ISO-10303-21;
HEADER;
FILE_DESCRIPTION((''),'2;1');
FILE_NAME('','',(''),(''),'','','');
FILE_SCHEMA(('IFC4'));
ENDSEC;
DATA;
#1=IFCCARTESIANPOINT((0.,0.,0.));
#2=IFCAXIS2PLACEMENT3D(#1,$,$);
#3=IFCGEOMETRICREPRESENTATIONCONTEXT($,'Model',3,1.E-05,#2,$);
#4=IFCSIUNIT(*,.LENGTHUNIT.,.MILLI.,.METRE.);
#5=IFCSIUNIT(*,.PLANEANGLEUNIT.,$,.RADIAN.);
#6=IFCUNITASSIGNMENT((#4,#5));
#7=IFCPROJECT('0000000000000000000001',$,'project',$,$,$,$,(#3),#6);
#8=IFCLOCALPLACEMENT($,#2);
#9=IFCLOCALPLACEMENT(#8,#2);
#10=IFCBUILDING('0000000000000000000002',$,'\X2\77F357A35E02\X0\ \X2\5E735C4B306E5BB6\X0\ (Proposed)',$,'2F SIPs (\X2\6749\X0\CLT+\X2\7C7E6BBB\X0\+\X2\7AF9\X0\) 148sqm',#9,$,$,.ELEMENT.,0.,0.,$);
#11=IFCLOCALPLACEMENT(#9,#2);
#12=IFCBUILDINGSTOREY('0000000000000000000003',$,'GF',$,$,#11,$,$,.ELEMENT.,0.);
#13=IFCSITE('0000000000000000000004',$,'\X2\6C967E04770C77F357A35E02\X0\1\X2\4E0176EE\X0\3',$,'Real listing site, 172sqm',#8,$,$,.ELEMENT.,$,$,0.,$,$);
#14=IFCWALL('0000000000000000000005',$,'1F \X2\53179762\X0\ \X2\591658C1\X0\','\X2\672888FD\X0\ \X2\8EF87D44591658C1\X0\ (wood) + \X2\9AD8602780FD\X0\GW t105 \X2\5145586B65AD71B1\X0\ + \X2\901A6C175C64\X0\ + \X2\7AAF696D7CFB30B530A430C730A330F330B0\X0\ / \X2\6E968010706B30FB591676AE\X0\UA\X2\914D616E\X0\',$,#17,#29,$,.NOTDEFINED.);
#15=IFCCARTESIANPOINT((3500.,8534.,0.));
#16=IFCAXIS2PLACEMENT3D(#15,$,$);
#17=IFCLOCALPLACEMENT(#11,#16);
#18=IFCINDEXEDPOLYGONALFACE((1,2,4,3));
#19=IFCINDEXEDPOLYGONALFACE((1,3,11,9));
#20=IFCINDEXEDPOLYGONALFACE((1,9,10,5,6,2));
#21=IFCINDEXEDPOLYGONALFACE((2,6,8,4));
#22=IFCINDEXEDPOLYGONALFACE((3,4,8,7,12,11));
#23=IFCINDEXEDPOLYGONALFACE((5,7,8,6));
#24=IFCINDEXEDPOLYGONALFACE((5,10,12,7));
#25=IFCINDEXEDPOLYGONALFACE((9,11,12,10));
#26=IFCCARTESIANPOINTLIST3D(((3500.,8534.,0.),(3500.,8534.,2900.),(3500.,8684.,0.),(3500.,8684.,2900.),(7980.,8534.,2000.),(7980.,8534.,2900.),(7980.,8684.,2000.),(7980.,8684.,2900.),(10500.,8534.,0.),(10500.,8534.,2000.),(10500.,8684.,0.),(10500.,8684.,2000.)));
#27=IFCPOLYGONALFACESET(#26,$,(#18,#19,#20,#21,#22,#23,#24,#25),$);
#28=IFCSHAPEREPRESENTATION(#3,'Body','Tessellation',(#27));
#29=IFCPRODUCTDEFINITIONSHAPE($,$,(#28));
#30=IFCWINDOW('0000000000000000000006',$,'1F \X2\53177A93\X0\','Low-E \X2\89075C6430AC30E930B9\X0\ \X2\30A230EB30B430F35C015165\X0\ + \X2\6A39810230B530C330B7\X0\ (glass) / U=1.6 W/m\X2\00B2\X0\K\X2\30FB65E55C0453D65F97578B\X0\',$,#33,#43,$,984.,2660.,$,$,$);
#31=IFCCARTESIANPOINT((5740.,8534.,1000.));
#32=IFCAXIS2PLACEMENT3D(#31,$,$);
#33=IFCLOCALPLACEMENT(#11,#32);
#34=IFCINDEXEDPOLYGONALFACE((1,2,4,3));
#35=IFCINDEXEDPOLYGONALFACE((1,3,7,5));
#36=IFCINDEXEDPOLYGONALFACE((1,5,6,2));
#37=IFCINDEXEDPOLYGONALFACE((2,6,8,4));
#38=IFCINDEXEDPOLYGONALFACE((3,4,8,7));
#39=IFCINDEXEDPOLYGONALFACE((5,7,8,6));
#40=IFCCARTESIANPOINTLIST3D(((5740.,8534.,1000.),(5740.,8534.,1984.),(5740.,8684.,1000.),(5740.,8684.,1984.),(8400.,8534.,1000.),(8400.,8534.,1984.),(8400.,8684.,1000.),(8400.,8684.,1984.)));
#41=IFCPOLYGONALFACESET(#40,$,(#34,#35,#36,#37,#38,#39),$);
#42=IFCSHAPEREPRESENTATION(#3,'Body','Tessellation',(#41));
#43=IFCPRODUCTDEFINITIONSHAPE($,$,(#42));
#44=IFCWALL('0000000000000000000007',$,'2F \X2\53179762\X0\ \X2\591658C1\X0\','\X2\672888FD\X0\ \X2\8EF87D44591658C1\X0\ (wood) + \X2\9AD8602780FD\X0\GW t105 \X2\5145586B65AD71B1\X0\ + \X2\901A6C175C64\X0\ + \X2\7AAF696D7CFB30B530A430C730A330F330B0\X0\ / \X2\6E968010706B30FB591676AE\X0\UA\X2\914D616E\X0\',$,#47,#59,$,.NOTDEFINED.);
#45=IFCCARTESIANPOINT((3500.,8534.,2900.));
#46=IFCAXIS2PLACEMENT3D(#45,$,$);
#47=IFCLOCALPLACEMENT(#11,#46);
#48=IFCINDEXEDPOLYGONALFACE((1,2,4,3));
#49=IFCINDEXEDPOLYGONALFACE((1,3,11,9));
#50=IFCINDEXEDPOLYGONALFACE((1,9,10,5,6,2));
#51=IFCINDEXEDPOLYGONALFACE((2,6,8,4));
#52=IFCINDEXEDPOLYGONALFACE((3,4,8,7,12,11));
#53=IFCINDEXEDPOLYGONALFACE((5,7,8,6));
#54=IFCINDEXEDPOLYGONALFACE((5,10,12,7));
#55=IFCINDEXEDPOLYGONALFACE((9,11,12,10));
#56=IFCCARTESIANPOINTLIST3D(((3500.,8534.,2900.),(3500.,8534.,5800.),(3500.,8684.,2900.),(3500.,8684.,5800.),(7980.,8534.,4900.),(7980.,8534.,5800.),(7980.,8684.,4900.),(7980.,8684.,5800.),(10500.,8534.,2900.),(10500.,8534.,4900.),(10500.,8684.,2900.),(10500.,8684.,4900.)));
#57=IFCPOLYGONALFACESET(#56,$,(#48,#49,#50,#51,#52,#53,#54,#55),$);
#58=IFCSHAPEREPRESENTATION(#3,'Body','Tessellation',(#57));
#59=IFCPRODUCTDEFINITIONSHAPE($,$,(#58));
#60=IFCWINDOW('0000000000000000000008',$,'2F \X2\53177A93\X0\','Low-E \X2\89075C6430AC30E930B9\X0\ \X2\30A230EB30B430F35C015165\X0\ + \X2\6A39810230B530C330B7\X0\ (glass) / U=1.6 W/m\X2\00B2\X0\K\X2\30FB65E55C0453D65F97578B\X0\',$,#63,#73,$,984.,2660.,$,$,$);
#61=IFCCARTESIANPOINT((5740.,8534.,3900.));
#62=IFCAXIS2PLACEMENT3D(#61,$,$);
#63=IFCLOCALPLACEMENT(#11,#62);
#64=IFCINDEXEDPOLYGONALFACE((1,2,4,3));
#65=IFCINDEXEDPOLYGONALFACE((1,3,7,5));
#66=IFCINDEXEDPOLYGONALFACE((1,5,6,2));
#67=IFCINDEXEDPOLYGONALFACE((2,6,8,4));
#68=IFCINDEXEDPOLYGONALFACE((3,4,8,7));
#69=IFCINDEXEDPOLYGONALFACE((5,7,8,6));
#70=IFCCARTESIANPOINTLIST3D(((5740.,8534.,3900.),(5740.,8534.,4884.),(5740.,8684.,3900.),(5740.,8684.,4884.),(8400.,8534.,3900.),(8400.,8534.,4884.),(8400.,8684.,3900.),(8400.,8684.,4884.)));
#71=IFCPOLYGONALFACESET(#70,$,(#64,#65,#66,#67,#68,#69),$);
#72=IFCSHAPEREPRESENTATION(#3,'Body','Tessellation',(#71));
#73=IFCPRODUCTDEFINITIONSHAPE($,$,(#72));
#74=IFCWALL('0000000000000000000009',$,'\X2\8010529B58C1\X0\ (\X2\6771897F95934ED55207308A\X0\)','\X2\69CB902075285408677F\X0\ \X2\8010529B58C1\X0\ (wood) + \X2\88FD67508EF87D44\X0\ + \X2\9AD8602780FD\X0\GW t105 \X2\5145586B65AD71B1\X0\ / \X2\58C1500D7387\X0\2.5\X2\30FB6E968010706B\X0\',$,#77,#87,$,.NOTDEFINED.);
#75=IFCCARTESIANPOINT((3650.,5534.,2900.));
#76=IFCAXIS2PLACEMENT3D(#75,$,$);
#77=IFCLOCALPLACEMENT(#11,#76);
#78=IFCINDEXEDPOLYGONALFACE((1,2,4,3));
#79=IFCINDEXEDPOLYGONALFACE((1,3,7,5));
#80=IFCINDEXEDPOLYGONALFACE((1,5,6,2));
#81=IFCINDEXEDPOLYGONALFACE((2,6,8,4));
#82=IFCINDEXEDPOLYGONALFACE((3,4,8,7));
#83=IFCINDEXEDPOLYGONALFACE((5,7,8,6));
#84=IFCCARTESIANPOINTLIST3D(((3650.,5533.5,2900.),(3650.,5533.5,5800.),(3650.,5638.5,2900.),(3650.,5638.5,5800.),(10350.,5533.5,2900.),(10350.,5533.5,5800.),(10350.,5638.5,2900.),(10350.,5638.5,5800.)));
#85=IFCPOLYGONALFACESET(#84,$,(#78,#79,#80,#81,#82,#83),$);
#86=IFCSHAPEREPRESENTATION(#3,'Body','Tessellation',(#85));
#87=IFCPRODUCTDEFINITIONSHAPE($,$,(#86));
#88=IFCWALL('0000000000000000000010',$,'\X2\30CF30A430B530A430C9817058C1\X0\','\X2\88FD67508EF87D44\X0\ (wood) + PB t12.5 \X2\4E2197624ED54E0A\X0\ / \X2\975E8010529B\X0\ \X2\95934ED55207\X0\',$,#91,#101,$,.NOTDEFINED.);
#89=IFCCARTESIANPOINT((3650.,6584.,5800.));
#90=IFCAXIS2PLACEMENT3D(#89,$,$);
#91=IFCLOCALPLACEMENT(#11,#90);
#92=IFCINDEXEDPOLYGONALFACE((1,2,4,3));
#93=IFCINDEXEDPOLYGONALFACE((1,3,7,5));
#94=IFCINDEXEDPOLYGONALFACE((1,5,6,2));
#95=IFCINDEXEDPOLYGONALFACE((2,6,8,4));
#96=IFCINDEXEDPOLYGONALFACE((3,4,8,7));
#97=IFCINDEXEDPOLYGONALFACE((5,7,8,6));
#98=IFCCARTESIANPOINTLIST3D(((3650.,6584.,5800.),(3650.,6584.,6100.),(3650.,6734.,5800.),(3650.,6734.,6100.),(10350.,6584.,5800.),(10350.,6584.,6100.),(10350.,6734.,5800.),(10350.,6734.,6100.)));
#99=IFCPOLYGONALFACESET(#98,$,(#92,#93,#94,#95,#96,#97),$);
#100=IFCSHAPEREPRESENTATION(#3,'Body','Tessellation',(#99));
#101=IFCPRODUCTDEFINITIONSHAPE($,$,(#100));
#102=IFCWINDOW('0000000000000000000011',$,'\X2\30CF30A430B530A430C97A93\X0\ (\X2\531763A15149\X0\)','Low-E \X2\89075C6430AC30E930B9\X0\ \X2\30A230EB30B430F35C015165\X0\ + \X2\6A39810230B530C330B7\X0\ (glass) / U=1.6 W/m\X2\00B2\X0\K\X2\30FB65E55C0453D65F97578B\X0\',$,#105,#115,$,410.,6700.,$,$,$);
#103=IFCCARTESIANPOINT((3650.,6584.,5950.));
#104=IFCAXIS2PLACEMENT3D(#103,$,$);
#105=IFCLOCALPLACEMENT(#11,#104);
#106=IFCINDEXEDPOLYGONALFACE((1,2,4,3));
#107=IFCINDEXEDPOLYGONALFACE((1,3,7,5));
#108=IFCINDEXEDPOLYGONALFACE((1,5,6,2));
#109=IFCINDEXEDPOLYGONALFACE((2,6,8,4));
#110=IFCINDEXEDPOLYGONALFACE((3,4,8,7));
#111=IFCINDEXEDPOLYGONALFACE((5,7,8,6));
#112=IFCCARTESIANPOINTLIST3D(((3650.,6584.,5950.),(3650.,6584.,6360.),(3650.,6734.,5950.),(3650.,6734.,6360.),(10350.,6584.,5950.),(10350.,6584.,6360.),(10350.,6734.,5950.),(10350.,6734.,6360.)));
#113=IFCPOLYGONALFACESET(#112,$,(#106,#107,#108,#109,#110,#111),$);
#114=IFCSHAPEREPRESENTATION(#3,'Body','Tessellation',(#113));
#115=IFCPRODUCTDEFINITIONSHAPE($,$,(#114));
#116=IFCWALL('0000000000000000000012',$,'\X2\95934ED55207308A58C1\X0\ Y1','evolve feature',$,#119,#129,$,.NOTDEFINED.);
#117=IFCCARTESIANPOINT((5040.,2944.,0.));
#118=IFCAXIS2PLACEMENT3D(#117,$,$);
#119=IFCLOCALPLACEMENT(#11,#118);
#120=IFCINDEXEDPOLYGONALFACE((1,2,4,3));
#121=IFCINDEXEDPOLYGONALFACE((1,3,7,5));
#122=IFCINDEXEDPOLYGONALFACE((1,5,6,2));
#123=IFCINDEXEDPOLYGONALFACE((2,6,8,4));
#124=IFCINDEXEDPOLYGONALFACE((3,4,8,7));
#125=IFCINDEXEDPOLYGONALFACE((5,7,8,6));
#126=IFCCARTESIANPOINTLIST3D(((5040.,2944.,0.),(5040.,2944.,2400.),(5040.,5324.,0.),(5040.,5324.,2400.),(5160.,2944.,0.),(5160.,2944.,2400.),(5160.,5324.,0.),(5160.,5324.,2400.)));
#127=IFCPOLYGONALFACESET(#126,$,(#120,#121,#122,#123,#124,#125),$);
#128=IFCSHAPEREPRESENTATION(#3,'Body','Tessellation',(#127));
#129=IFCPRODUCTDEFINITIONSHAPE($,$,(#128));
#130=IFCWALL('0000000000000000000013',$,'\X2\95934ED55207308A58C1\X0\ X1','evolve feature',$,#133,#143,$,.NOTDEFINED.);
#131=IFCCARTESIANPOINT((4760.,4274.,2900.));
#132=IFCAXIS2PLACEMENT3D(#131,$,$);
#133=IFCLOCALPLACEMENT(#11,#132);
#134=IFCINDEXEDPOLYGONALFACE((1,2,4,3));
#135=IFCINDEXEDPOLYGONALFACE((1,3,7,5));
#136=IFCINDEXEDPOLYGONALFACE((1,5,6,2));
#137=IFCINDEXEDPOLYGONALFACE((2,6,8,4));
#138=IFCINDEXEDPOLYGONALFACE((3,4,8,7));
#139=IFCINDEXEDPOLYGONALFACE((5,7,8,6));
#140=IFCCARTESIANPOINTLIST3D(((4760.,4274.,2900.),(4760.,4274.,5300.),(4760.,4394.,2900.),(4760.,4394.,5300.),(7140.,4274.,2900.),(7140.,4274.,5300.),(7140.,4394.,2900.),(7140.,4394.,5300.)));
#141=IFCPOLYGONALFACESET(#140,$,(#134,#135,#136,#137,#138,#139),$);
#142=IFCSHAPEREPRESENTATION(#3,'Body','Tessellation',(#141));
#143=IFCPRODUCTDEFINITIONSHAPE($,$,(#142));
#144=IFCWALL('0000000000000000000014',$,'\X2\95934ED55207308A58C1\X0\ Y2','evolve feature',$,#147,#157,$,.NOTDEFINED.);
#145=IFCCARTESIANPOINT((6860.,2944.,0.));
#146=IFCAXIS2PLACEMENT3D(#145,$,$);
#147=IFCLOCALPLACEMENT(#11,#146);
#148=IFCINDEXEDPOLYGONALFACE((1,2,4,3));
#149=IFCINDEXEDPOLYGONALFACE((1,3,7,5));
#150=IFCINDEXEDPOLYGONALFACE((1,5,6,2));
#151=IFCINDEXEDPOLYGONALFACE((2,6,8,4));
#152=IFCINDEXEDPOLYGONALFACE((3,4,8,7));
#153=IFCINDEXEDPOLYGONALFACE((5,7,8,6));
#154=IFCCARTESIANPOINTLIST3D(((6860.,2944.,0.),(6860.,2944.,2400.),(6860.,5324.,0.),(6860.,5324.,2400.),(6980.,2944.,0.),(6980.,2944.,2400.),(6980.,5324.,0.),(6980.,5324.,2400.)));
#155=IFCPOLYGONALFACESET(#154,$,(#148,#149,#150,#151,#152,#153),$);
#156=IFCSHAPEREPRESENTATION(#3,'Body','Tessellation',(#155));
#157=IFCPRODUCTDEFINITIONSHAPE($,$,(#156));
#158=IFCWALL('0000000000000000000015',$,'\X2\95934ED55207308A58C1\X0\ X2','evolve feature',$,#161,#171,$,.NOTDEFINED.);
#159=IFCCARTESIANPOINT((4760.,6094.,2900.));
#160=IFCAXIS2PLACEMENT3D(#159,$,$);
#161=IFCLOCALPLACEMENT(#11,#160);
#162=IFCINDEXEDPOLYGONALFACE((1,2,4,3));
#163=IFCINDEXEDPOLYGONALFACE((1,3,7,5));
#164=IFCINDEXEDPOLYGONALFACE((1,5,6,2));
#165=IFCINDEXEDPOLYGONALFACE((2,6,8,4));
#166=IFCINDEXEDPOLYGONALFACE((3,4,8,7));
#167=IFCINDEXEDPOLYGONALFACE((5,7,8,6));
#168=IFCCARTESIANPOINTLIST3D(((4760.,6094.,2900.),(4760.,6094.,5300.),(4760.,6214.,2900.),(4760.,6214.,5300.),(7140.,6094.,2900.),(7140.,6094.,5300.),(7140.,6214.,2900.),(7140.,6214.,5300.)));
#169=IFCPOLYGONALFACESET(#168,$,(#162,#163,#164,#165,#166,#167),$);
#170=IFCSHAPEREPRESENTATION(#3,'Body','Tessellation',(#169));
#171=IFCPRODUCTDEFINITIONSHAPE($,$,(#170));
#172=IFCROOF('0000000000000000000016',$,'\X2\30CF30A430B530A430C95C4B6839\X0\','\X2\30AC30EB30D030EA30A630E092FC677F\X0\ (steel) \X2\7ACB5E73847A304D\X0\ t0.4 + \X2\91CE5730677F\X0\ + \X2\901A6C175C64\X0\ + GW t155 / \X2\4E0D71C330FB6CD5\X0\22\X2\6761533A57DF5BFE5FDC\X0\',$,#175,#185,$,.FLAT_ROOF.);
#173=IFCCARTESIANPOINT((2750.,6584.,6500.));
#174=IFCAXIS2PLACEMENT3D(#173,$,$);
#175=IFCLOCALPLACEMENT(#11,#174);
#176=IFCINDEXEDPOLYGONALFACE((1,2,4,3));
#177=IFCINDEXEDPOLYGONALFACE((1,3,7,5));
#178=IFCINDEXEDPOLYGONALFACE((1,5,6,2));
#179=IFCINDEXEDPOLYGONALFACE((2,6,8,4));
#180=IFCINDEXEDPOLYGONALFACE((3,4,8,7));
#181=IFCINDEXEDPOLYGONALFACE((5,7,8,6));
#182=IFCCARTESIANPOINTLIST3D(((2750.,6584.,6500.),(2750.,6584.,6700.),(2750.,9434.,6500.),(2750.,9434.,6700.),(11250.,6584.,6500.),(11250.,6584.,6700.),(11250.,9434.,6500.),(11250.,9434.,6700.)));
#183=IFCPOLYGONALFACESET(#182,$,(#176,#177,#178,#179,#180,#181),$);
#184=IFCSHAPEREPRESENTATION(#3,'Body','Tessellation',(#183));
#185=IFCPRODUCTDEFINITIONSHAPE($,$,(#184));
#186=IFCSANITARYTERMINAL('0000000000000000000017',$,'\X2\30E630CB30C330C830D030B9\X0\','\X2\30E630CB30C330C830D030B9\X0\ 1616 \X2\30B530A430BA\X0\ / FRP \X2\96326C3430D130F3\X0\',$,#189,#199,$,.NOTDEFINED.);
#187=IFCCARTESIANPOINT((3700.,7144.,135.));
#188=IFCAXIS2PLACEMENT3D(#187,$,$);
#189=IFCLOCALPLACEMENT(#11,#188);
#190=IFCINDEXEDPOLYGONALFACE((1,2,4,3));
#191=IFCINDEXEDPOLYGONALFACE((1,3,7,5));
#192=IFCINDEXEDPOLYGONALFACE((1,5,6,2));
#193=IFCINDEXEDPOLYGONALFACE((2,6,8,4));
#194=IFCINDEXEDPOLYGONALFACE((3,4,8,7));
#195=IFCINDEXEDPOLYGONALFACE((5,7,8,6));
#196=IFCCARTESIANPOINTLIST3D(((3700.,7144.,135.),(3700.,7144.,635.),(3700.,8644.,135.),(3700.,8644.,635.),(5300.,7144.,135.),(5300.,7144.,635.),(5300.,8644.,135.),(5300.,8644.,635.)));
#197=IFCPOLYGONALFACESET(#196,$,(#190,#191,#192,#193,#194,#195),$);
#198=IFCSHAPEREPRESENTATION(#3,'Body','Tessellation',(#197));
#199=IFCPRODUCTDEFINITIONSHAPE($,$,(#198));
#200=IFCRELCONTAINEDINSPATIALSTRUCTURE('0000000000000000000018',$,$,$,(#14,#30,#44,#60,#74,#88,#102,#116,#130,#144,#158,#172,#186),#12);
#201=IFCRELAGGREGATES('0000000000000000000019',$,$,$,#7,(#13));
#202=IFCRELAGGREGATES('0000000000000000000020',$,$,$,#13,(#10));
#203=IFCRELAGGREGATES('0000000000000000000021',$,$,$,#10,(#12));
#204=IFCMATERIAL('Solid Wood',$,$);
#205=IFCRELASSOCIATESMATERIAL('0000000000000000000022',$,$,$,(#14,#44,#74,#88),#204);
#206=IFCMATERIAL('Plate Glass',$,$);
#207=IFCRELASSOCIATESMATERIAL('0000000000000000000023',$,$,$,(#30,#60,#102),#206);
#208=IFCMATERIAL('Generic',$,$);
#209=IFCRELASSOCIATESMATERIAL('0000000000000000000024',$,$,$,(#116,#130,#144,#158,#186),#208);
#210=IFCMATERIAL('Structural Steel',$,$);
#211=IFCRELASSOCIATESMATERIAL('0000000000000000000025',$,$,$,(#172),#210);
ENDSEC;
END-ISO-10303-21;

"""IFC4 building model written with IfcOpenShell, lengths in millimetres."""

from ifc_helpers import new_model, si_unit, frame, frame_2d, origin, place, context, project, spatial, rectangle, extrude, material, element, fill, save


model = new_model("IFC4")

# Units and contexts
model_context = context("Model", 3, precision=1e-05, world=origin())
ifc_project = project(units=[si_unit("LENGTHUNIT", "METRE", prefix="MILLI"), si_unit("PLANEANGLEUNIT", "RADIAN")], contexts=[model_context])

# Site, building, storey
site_placement = place(None, origin())
site = spatial("IfcSite", under=ifc_project, at=site_placement, Name="沖縄県石垣市1丁目3", ObjectType="Real listing site, 172sqm", CompositionType="ELEMENT", RefElevation=0.0)
building_placement = place(site_placement, origin())
building = spatial("IfcBuilding", under=site, at=building_placement, Name="石垣市 平屋の家 (Proposed)", ObjectType="2F SIPs (杉CLT+籾殻+竹) 148sqm", CompositionType="ELEMENT", ElevationOfRefHeight=0.0, ElevationOfTerrain=0.0)
storey_placement = place(building_placement, origin())
storey = spatial("IfcBuildingStorey", under=building, at=storey_placement, Name="GF", CompositionType="ELEMENT", Elevation=0.0)

# Wall, opening, window
ifc_material_1 = material(Name="Solid Wood")
wall_1_placement = place(storey_placement, frame((3500.0, 8534.0, 0.0)))
wall_1 = element("IfcWall", 1, at=wall_1_placement, inside=storey, material=ifc_material_1, Name="1F 北面 外壁", Description="木製 軸組外壁 (wood) + 高性能GW t105 充填断熱 + 通気層 + 窯業系サイディング / 準耐火・外皮UA配慮", PredefinedType="NOTDEFINED", context=model_context, shape_type="SweptSolid", body=[
    extrude(rectangle(XDim=7000.0, YDim=150.0, at=frame_2d((3500.0, 75.0))), frame((3500.0, 8534.0, 0.0)), (0.0, 0.0, 1.0), 2900.0),
])
opening_1_placement = place(storey_placement, frame((5740.0, 8534.0, 1000.0)))
opening_1 = element("IfcOpeningElement", 2, at=opening_1_placement, cuts=wall_1, PredefinedType="NOTDEFINED", context=model_context, shape_type="SweptSolid", body=[
    extrude(rectangle(XDim=2660.0, YDim=150.0, at=frame_2d((1330.0, 75.0))), frame((5740.0, 8534.0, 1000.0)), (0.0, 0.0, 1.0), 984.0),
])
ifc_material_2 = material(Name="Plate Glass")
window_1_placement = place(storey_placement, frame((5740.0, 8534.0, 1000.0)))
window_1 = element("IfcWindow", 3, at=window_1_placement, inside=storey, material=ifc_material_2, Name="1F 北窓", Description="Low-E 複層ガラス アルゴン封入 + 樹脂サッシ (glass) / U=1.6 W/m²K・日射取得型", OverallHeight=984.0, OverallWidth=2660.0, context=model_context, shape_type="SweptSolid", body=[
    extrude(rectangle(XDim=2660.0, YDim=150.0, at=frame_2d((1330.0, 75.0))), frame((5740.0, 8534.0, 1000.0)), (0.0, 0.0, 1.0), 984.0),
])
fill(opening_1, window_1)

# Wall, opening, window
wall_2_placement = place(storey_placement, frame((3500.0, 8534.0, 2900.0)))
wall_2 = element("IfcWall", 4, at=wall_2_placement, inside=storey, material=ifc_material_1, Name="2F 北面 外壁", Description="木製 軸組外壁 (wood) + 高性能GW t105 充填断熱 + 通気層 + 窯業系サイディング / 準耐火・外皮UA配慮", PredefinedType="NOTDEFINED", context=model_context, shape_type="SweptSolid", body=[
    extrude(rectangle(XDim=7000.0, YDim=150.0, at=frame_2d((3500.0, 75.0))), frame((3500.0, 8534.0, 2900.0)), (0.0, 0.0, 1.0), 2900.0),
])
opening_2_placement = place(storey_placement, frame((5740.0, 8534.0, 3900.0)))
opening_2 = element("IfcOpeningElement", 5, at=opening_2_placement, cuts=wall_2, PredefinedType="NOTDEFINED", context=model_context, shape_type="SweptSolid", body=[
    extrude(rectangle(XDim=2660.0, YDim=150.0, at=frame_2d((1330.0, 75.0))), frame((5740.0, 8534.0, 3900.0)), (0.0, 0.0, 1.0), 984.0),
])
window_2_placement = place(storey_placement, frame((5740.0, 8534.0, 3900.0)))
window_2 = element("IfcWindow", 6, at=window_2_placement, inside=storey, material=ifc_material_2, Name="2F 北窓", Description="Low-E 複層ガラス アルゴン封入 + 樹脂サッシ (glass) / U=1.6 W/m²K・日射取得型", OverallHeight=984.0, OverallWidth=2660.0, context=model_context, shape_type="SweptSolid", body=[
    extrude(rectangle(XDim=2660.0, YDim=150.0, at=frame_2d((1330.0, 75.0))), frame((5740.0, 8534.0, 3900.0)), (0.0, 0.0, 1.0), 984.0),
])
fill(opening_2, window_2)

# Wall
wall_3_placement = place(storey_placement, frame((3650.0, 5534.0, 2900.0)))
element("IfcWall", 7, at=wall_3_placement, inside=storey, material=ifc_material_1, Name="耐力壁 (東西間仕切り)", Description="構造用合板 耐力壁 (wood) + 製材軸組 + 高性能GW t105 充填断熱 / 壁倍率2.5・準耐火", PredefinedType="NOTDEFINED", context=model_context, shape_type="SweptSolid", body=[
    extrude(rectangle(XDim=6700.0, YDim=105.0, at=frame_2d((3350.0, 52.0))), frame((3650.0, 5534.0, 2900.0)), (0.0, 0.0, 1.0), 2900.0),
])

# Wall, opening, window
wall_4_placement = place(storey_placement, frame((3650.0, 6584.0, 5800.0)))
wall_4 = element("IfcWall", 8, at=wall_4_placement, inside=storey, material=ifc_material_1, Name="ハイサイド腰壁", Description="製材軸組 (wood) + PB t12.5 両面仕上 / 非耐力 間仕切", PredefinedType="NOTDEFINED", context=model_context, shape_type="SweptSolid", body=[
    extrude(rectangle(XDim=6700.0, YDim=150.0, at=frame_2d((3350.0, 75.0))), frame((3650.0, 6584.0, 5800.0)), (0.0, 0.0, 1.0), 700.0),
])
opening_3_placement = place(storey_placement, frame((3650.0, 6584.0, 5950.0)))
opening_3 = element("IfcOpeningElement", 9, at=opening_3_placement, cuts=wall_4, PredefinedType="NOTDEFINED", context=model_context, shape_type="SweptSolid", body=[
    extrude(rectangle(XDim=6700.0, YDim=150.0, at=frame_2d((3350.0, 75.0))), frame((3650.0, 6584.0, 5950.0)), (0.0, 0.0, 1.0), 410.0),
])
window_3_placement = place(storey_placement, frame((3650.0, 6584.0, 5950.0)))
window_3 = element("IfcWindow", 10, at=window_3_placement, inside=storey, material=ifc_material_2, Name="ハイサイド窓 (北採光)", Description="Low-E 複層ガラス アルゴン封入 + 樹脂サッシ (glass) / U=1.6 W/m²K・日射取得型", OverallHeight=410.0, OverallWidth=6700.0, context=model_context, shape_type="SweptSolid", body=[
    extrude(rectangle(XDim=6700.0, YDim=150.0, at=frame_2d((3350.0, 75.0))), frame((3650.0, 6584.0, 5950.0)), (0.0, 0.0, 1.0), 410.0),
])
fill(opening_3, window_3)

# Walls
ifc_material_3 = material(Name="Generic")
wall_5_placement = place(storey_placement, frame((5040.0, 2944.0, 0.0)))
element("IfcWall", 11, at=wall_5_placement, inside=storey, material=ifc_material_3, Name="間仕切り壁 Y1", Description="evolve feature", PredefinedType="NOTDEFINED", context=model_context, shape_type="SweptSolid", body=[
    extrude(rectangle(XDim=120.0, YDim=2380.0, at=frame_2d((60.0, 1190.0))), frame((5040.0, 2944.0, 0.0)), (0.0, 0.0, 1.0), 2400.0),
])
wall_6_placement = place(storey_placement, frame((4760.0, 4274.0, 2900.0)))
element("IfcWall", 12, at=wall_6_placement, inside=storey, material=ifc_material_3, Name="間仕切り壁 X1", Description="evolve feature", PredefinedType="NOTDEFINED", context=model_context, shape_type="SweptSolid", body=[
    extrude(rectangle(XDim=2380.0, YDim=120.0, at=frame_2d((1190.0, 60.0))), frame((4760.0, 4274.0, 2900.0)), (0.0, 0.0, 1.0), 2400.0),
])
wall_7_placement = place(storey_placement, frame((6860.0, 2944.0, 0.0)))
element("IfcWall", 13, at=wall_7_placement, inside=storey, material=ifc_material_3, Name="間仕切り壁 Y2", Description="evolve feature", PredefinedType="NOTDEFINED", context=model_context, shape_type="SweptSolid", body=[
    extrude(rectangle(XDim=120.0, YDim=2380.0, at=frame_2d((60.0, 1190.0))), frame((6860.0, 2944.0, 0.0)), (0.0, 0.0, 1.0), 2400.0),
])
wall_8_placement = place(storey_placement, frame((4760.0, 6094.0, 2900.0)))
element("IfcWall", 14, at=wall_8_placement, inside=storey, material=ifc_material_3, Name="間仕切り壁 X2", Description="evolve feature", PredefinedType="NOTDEFINED", context=model_context, shape_type="SweptSolid", body=[
    extrude(rectangle(XDim=2380.0, YDim=120.0, at=frame_2d((1190.0, 60.0))), frame((4760.0, 6094.0, 2900.0)), (0.0, 0.0, 1.0), 2400.0),
])

# Roof
ifc_material_4 = material(Name="Structural Steel")
roof_placement = place(storey_placement, frame((2750.0, 6584.0, 6500.0)))
element("IfcRoof", 15, at=roof_placement, inside=storey, material=ifc_material_4, Name="ハイサイド屋根", Description="ガルバリウム鋼板 (steel) 立平葺き t0.4 + 野地板 + 通気層 + GW t155 / 不燃・法22条区域対応", PredefinedType="FLAT_ROOF", context=model_context, shape_type="SweptSolid", body=[
    extrude(rectangle(XDim=8500.0, YDim=2850.0, at=frame_2d((4250.0, 1425.0))), frame((2750.0, 6584.0, 6500.0)), (0.0, 0.0, 1.0), 200.0),
])

# Sanitary terminal
sanitary_terminal_1_placement = place(storey_placement, frame((3700.0, 7144.0, 135.0)))
element("IfcSanitaryTerminal", 16, at=sanitary_terminal_1_placement, inside=storey, material=ifc_material_3, Name="ユニットバス", Description="ユニットバス 1616 サイズ / FRP 防水パン", PredefinedType="NOTDEFINED", context=model_context, shape_type="SweptSolid", body=[
    extrude(rectangle(XDim=1600.0, YDim=1500.0, at=frame_2d((800.0, 750.0))), frame((3700.0, 7144.0, 135.0)), (0.0, 0.0, 1.0), 500.0),
])

save(model, "model.ifc")
